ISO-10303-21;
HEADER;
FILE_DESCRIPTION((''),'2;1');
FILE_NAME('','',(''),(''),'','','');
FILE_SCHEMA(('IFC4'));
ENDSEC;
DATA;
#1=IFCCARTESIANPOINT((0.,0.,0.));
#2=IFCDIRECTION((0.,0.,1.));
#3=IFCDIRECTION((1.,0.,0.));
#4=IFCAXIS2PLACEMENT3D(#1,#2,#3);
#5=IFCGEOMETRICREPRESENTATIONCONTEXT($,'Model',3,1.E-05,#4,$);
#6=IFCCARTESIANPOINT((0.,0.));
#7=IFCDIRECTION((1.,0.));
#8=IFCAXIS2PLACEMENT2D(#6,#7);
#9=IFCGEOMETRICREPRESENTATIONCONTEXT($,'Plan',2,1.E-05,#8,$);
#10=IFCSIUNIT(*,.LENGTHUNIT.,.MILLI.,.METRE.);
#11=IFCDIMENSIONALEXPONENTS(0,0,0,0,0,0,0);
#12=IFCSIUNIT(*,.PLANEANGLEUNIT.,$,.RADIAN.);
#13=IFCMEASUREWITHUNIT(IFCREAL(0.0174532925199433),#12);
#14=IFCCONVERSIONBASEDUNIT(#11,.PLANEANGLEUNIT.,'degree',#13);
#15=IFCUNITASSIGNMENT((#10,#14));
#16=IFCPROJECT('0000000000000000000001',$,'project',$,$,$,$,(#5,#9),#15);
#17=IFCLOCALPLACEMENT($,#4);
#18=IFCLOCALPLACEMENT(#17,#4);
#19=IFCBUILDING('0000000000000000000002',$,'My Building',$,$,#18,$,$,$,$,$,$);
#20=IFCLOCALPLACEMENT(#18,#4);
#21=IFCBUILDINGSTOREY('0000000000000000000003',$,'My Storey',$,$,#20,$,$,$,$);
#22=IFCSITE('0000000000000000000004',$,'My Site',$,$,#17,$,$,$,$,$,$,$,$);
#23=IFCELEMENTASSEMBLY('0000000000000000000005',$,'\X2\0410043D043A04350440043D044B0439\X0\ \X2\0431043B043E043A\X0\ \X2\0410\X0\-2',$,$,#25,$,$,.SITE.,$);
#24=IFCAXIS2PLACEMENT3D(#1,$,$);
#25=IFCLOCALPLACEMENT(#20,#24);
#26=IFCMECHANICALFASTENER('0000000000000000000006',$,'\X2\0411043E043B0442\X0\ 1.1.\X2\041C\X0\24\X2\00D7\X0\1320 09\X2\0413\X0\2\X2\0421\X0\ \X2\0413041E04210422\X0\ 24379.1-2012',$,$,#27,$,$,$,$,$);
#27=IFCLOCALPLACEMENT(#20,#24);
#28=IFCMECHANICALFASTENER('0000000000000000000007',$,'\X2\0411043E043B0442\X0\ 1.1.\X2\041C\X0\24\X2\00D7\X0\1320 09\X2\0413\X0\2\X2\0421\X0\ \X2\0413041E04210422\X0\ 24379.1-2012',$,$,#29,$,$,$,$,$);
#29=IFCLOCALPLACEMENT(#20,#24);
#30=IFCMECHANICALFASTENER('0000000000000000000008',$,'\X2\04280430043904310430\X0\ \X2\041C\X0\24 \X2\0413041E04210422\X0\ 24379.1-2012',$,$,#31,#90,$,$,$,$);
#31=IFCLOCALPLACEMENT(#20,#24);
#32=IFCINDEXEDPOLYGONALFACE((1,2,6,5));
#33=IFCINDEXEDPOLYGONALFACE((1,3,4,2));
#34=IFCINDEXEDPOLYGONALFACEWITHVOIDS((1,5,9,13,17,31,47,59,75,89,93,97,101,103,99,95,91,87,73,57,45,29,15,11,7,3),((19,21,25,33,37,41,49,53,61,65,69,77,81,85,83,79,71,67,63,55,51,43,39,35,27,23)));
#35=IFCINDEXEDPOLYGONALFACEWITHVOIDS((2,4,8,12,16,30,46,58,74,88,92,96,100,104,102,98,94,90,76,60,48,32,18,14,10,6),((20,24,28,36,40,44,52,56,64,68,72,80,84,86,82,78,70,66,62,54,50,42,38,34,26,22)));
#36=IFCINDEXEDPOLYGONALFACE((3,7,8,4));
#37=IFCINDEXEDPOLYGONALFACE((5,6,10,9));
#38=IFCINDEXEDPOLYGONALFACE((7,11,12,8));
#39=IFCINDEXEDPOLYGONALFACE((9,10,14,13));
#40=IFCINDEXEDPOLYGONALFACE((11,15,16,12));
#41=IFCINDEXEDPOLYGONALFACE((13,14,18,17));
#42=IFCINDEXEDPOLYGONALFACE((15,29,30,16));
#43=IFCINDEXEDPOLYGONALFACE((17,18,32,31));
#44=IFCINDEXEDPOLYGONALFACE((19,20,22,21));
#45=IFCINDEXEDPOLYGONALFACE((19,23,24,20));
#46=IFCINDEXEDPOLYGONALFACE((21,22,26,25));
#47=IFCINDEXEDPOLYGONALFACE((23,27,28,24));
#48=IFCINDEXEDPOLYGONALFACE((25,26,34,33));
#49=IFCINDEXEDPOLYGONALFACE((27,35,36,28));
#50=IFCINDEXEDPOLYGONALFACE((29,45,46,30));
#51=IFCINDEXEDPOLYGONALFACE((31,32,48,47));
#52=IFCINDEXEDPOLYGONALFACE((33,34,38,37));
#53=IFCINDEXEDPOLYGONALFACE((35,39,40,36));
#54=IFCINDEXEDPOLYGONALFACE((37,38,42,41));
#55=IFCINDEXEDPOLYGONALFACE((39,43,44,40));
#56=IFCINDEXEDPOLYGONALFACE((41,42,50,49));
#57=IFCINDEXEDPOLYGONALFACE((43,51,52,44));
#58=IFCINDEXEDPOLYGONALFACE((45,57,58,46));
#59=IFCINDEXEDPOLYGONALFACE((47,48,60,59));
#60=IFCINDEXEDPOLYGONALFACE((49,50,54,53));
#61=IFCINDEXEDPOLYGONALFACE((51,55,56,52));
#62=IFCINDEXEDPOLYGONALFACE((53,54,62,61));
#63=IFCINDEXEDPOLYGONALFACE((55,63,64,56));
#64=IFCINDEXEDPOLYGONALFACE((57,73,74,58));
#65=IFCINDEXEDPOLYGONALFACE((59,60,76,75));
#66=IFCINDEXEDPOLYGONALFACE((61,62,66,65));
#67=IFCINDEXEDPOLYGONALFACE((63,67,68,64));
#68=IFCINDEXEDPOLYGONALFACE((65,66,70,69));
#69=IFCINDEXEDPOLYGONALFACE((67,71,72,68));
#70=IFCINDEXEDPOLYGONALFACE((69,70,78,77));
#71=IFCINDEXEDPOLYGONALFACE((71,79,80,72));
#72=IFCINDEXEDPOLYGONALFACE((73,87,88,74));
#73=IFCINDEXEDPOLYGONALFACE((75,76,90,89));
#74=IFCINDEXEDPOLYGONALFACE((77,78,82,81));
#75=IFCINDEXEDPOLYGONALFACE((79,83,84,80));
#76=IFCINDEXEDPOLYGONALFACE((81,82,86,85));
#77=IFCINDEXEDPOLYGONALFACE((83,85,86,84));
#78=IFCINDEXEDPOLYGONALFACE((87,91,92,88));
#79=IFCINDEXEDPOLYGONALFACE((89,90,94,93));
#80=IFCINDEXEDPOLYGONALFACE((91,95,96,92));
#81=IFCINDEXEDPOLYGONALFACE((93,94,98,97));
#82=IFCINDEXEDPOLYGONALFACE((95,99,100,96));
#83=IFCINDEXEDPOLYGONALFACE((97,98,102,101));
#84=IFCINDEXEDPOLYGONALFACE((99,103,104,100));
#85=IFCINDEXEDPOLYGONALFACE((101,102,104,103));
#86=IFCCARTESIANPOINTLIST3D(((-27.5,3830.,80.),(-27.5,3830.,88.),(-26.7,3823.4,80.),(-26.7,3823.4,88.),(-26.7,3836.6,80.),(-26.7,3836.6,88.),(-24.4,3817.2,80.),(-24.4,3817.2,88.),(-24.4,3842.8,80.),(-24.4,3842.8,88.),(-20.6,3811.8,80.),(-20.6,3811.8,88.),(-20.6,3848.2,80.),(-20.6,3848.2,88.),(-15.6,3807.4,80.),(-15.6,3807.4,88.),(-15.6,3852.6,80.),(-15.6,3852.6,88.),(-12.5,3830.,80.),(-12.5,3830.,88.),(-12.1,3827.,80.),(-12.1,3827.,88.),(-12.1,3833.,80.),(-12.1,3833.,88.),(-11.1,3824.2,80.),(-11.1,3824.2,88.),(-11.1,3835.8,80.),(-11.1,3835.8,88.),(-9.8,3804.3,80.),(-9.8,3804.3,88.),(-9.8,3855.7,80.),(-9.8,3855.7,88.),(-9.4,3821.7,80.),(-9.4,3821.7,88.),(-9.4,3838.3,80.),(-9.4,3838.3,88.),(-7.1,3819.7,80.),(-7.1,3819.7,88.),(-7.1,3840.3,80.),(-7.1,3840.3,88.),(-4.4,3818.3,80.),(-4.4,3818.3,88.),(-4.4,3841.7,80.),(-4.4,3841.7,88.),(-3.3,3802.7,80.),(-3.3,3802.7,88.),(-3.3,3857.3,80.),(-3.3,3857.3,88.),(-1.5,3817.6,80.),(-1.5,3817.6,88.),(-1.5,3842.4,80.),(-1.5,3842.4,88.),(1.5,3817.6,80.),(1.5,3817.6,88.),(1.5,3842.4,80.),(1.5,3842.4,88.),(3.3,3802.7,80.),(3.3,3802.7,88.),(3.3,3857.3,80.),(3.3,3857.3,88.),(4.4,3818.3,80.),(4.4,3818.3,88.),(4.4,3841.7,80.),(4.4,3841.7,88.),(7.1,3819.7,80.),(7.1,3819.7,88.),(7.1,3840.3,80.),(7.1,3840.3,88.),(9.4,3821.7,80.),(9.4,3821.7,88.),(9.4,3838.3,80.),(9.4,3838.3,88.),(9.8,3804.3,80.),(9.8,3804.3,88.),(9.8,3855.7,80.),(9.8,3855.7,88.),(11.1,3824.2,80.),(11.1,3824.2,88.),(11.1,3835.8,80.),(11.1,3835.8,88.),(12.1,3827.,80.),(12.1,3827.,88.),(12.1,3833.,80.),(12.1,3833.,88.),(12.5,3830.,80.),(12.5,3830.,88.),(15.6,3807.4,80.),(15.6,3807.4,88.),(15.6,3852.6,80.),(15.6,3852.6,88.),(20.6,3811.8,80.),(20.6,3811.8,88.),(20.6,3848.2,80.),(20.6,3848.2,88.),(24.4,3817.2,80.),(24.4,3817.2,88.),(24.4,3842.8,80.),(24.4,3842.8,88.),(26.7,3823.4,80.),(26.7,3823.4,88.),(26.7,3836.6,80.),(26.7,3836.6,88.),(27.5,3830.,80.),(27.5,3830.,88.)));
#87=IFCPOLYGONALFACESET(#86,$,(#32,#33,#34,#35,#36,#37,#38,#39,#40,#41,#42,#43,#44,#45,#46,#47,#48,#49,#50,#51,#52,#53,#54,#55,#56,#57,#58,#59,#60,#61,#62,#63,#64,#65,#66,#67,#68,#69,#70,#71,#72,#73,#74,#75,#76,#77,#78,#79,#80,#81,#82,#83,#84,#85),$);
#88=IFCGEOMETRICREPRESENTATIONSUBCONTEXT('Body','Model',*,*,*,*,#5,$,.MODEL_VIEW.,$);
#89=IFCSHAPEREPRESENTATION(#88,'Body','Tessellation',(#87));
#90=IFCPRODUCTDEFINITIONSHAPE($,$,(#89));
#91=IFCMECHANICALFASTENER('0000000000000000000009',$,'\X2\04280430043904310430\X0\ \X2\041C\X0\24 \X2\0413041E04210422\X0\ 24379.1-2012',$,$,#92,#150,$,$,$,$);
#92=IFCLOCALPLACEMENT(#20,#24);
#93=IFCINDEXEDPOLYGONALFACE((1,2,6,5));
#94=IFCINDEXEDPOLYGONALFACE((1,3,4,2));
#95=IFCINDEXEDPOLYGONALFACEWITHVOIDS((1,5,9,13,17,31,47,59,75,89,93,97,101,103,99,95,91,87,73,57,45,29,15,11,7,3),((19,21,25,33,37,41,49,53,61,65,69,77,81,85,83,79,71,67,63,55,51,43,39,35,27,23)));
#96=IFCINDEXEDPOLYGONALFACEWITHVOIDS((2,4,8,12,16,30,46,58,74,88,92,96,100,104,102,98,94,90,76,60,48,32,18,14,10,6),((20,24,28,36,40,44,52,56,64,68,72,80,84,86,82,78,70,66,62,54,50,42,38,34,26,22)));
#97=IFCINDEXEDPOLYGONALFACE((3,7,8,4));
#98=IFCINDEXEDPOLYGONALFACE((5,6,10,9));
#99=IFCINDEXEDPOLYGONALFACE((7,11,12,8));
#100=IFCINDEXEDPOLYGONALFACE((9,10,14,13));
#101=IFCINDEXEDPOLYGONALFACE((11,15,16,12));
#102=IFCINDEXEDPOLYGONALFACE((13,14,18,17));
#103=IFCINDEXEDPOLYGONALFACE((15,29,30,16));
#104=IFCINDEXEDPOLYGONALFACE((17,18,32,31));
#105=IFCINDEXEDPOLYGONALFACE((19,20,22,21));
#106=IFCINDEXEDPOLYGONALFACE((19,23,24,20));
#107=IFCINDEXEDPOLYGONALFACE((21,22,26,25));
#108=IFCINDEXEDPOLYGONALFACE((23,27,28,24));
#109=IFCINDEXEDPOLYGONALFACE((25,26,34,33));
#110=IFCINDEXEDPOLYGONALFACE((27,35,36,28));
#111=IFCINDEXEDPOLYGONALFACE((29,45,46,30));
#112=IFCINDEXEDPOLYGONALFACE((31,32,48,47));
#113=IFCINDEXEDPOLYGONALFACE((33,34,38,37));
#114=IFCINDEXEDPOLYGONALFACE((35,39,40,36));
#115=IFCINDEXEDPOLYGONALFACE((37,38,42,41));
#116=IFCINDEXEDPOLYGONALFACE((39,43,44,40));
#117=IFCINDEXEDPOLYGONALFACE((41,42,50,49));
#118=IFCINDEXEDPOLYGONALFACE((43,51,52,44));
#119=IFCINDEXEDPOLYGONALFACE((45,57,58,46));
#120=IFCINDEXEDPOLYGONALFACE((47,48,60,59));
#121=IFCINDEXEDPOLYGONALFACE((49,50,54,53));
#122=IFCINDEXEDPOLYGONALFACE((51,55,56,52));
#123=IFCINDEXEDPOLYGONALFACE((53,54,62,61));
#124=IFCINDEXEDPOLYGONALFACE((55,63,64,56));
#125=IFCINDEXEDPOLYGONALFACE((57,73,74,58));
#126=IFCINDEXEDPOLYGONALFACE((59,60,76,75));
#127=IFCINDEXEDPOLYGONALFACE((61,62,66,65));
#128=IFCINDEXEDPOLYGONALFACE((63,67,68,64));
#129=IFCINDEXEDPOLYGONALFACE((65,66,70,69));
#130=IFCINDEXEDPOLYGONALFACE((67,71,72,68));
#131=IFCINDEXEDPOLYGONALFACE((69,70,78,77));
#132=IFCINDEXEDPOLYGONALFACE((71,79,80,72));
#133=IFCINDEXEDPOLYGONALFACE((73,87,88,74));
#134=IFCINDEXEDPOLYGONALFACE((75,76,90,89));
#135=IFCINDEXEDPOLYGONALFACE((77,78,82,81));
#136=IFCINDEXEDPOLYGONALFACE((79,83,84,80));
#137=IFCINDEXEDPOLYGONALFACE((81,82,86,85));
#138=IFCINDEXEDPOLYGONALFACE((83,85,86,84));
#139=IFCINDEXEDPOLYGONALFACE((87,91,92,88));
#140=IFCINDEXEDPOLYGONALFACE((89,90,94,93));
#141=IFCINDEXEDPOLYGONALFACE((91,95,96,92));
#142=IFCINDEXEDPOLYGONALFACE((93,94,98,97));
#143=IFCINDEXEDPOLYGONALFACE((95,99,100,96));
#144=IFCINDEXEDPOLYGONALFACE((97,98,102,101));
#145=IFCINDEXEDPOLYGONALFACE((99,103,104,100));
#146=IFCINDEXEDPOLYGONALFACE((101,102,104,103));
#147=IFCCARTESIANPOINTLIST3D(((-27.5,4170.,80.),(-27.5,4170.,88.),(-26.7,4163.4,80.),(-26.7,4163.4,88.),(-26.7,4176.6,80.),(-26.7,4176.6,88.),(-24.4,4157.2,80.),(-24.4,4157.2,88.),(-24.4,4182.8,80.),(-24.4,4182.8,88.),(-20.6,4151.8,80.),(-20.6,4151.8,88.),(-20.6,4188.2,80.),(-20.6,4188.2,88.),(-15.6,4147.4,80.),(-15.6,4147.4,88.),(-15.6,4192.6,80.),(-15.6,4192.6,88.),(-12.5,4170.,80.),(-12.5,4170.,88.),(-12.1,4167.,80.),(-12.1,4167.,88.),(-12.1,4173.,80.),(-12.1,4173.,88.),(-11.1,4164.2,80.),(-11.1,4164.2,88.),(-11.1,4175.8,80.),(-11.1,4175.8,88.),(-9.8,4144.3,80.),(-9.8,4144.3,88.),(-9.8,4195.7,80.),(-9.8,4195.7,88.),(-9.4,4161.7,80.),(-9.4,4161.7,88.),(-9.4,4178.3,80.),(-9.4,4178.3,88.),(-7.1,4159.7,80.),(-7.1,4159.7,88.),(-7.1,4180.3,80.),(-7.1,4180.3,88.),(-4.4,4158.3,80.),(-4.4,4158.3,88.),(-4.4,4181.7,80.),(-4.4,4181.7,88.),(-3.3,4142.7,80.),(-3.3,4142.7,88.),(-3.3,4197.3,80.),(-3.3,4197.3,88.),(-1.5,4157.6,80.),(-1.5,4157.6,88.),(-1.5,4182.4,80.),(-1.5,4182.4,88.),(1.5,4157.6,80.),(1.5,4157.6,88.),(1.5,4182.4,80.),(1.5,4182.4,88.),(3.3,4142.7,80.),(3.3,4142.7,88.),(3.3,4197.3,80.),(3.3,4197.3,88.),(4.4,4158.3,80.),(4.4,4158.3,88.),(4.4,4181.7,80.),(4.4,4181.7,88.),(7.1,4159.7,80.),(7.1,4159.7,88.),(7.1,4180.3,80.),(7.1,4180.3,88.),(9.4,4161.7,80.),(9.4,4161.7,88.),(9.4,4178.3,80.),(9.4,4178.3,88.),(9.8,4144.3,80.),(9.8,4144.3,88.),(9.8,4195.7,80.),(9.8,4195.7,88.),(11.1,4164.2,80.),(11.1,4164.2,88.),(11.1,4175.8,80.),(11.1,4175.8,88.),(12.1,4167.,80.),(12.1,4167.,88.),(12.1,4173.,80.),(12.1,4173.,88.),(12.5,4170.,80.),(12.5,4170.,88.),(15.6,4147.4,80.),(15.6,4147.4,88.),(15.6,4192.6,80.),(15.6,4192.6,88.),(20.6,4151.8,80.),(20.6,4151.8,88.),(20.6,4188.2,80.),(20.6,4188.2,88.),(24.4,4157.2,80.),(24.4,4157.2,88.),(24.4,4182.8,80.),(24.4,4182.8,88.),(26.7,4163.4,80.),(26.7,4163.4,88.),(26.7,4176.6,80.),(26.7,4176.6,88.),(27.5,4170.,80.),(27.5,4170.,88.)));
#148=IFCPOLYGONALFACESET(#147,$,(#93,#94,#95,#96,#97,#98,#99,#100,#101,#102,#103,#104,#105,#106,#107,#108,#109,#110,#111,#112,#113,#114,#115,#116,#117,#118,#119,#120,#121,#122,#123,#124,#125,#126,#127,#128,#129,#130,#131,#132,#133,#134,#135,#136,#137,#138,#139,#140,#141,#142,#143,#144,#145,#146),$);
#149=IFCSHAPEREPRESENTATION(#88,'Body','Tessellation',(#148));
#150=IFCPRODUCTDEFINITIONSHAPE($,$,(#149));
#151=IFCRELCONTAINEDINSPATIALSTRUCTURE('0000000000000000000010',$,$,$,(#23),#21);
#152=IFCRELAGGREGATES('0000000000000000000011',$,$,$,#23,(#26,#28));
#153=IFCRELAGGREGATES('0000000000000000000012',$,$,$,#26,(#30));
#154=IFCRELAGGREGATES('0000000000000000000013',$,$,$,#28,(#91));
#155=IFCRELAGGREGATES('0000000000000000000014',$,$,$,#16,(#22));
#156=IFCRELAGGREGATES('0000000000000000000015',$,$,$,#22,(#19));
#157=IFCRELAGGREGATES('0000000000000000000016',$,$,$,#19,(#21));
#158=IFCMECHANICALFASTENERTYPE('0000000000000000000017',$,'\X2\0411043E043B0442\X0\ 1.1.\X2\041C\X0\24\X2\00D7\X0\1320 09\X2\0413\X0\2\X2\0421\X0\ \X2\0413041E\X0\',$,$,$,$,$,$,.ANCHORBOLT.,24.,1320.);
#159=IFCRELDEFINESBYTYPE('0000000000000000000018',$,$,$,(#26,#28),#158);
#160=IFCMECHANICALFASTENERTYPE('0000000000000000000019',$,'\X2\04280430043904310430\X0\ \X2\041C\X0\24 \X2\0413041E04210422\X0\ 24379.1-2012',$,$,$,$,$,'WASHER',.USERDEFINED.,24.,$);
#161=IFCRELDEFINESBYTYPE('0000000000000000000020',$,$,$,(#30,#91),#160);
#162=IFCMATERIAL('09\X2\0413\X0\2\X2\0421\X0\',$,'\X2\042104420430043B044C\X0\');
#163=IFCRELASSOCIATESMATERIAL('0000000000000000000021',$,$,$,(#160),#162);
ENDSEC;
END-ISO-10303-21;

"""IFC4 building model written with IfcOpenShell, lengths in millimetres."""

from ifc_helpers import new_model, entity, si_unit, converted_unit, frame, origin_with_axes, origin_2d_with_axis, place, context, subcontext, project, spatial, polyline, outline, extrude, source, transform, mapped, material, type_object, type_shapes, element, aggregate, save


model = new_model("IFC4")

# Units and contexts
model_context = context("Model", 3, precision=1e-05, world=origin_with_axes())
plan_context = context("Plan", 2, precision=1e-05, world=origin_2d_with_axis())
body_context = subcontext(model_context, "Body", "Model", "MODEL_VIEW")
ifc_project = project(units=[si_unit("LENGTHUNIT", "METRE", prefix="MILLI"), converted_unit("PLANEANGLEUNIT", "degree", entity("IfcReal", 0.0174532925199433), si_unit("PLANEANGLEUNIT", "RADIAN"), dimensions=[0, 0, 0, 0, 0, 0, 0])], contexts=[model_context, plan_context])

# Site, building, storey
site_placement = place(None, origin_with_axes())
site = spatial("IfcSite", under=ifc_project, at=site_placement, Name="My Site")
building_placement = place(site_placement, origin_with_axes())
building = spatial("IfcBuilding", under=site, at=building_placement, Name="My Building")
storey_placement = place(building_placement, origin_with_axes())
storey = spatial("IfcBuildingStorey", under=building, at=storey_placement, Name="My Storey")

# Shared definitions
placement_1 = place(storey_placement, frame((0.0, 4000.0, 0.0), z_axis=(0.0, 0.0, 1.0), x_axis=(1.0, 0.0, 0.0)))

# Element assembly, mechanical fasteners
ifc_material_1 = material(Name="09Г2С", Category="Сталь")
mechanical_fastener_type_1 = type_object("IfcMechanicalFastenerType", Name="Болт 1.1.М24×1320 09Г2С ГО", NominalDiameter=24.0, NominalLength=1320.0, PredefinedType="ANCHORBOLT")
assembly_1 = element("IfcElementAssembly", 1, at=placement_1, inside=storey, Name="Анкерный блок А-2", AssemblyPlace="SITE")
mechanical_fastener_1_placement = place(placement_1, frame((0.0, -170.0, 0.0), z_axis=(0.0, 0.0, 1.0), x_axis=(1.0, 0.0, 0.0)))
mechanical_fastener_1 = element("IfcMechanicalFastener", 2, at=mechanical_fastener_1_placement, type_object=mechanical_fastener_type_1, Name="Болт 1.1.М24×1320 09Г2С ГОСТ 24379.1-2012")
mechanical_fastener_2_placement = place(placement_1, frame((0.0, 170.0, 0.0), z_axis=(0.0, 0.0, 1.0), x_axis=(-1.0, 0.0, 0.0)))
mechanical_fastener_2 = element("IfcMechanicalFastener", 3, at=mechanical_fastener_2_placement, type_object=mechanical_fastener_type_1, Name="Болт 1.1.М24×1320 09Г2С ГОСТ 24379.1-2012")
aggregate(assembly_1, [mechanical_fastener_1, mechanical_fastener_2])

# Mechanical fasteners
mechanical_fastener_type_2 = type_object("IfcMechanicalFastenerType", Name="Шайба М24 ГОСТ 24379.1-2012", ElementType="WASHER", NominalDiameter=24.0, PredefinedType="USERDEFINED", material=ifc_material_1)
shared_shape_1 = source(origin_with_axes(), body_context, "Body", "SweptSolid", [
    extrude(outline(polyline([(27.5, 0.0), (26.7, 6.6), (24.4, 12.8), (20.6, 18.2), (15.6, 22.6), (9.8, 25.7), (3.3, 27.3), (-3.3, 27.3), (-9.8, 25.7), (-15.6, 22.6), (-20.6, 18.2), (-24.4, 12.8), (-26.7, 6.6), (-27.5, 0.0), (-26.7, -6.6), (-24.4, -12.8), (-20.6, -18.2), (-15.6, -22.6), (-9.8, -25.7), (-3.3, -27.3), (3.3, -27.3), (9.8, -25.7), (15.6, -22.6), (20.6, -18.2), (24.4, -12.8), (26.7, -6.6), (27.5, 0.0)]), holes=[polyline([(-4.4, -11.7), (-7.1, -10.3), (-9.4, -8.3), (-11.1, -5.8), (-12.1, -3.0), (-12.5, 0.0), (-12.1, 3.0), (-11.1, 5.8), (-9.4, 8.3), (-7.1, 10.3), (-4.4, 11.7), (-1.5, 12.4), (1.5, 12.4), (4.4, 11.7), (7.1, 10.3), (9.4, 8.3), (11.1, 5.8), (12.1, 3.0), (12.5, 0.0), (12.1, -3.0), (11.1, -5.8), (9.4, -8.3), (7.1, -10.3), (4.4, -11.7), (1.5, -12.4), (-1.5, -12.4), (-4.4, -11.7)])]), frame((0.0, 0.0, 0.0), z_axis=(0.0, 0.0, 1.0), x_axis=(0.120537, -0.992709, 0.0)), (0.0, 0.0, 1.0), 8.0),
])
type_shapes(mechanical_fastener_type_2, [shared_shape_1])
mechanical_fastener_3_placement = place(mechanical_fastener_1_placement, frame((0.0, 0.0, 80.0), z_axis=(0.0, 0.0, 1.0), x_axis=(1.0, 0.0, 0.0)))
mechanical_fastener_3 = element("IfcMechanicalFastener", 4, at=mechanical_fastener_3_placement, type_object=mechanical_fastener_type_2, Name="Шайба М24 ГОСТ 24379.1-2012", context=body_context, shape_type="MappedRepresentation", body=[
    mapped(shared_shape_1, transform((0.0, 0.0, 0.0), x_axis=(1.0, 0.0, 0.0), y_axis=(0.0, 1.0, 0.0), z_axis=(0.0, 0.0, 1.0), scale=1.0)),
])
aggregate(mechanical_fastener_1, [mechanical_fastener_3])
mechanical_fastener_4_placement = place(mechanical_fastener_2_placement, frame((0.0, 0.0, 80.0), z_axis=(0.0, 0.0, 1.0), x_axis=(1.0, 0.0, 0.0)))
mechanical_fastener_4 = element("IfcMechanicalFastener", 5, at=mechanical_fastener_4_placement, type_object=mechanical_fastener_type_2, Name="Шайба М24 ГОСТ 24379.1-2012", context=body_context, shape_type="MappedRepresentation", body=[
    mapped(shared_shape_1, transform((0.0, 0.0, 0.0), x_axis=(1.0, 0.0, 0.0), y_axis=(0.0, 1.0, 0.0), z_axis=(0.0, 0.0, 1.0), scale=1.0)),
])
aggregate(mechanical_fastener_2, [mechanical_fastener_4])

save(model, "model.ifc")
